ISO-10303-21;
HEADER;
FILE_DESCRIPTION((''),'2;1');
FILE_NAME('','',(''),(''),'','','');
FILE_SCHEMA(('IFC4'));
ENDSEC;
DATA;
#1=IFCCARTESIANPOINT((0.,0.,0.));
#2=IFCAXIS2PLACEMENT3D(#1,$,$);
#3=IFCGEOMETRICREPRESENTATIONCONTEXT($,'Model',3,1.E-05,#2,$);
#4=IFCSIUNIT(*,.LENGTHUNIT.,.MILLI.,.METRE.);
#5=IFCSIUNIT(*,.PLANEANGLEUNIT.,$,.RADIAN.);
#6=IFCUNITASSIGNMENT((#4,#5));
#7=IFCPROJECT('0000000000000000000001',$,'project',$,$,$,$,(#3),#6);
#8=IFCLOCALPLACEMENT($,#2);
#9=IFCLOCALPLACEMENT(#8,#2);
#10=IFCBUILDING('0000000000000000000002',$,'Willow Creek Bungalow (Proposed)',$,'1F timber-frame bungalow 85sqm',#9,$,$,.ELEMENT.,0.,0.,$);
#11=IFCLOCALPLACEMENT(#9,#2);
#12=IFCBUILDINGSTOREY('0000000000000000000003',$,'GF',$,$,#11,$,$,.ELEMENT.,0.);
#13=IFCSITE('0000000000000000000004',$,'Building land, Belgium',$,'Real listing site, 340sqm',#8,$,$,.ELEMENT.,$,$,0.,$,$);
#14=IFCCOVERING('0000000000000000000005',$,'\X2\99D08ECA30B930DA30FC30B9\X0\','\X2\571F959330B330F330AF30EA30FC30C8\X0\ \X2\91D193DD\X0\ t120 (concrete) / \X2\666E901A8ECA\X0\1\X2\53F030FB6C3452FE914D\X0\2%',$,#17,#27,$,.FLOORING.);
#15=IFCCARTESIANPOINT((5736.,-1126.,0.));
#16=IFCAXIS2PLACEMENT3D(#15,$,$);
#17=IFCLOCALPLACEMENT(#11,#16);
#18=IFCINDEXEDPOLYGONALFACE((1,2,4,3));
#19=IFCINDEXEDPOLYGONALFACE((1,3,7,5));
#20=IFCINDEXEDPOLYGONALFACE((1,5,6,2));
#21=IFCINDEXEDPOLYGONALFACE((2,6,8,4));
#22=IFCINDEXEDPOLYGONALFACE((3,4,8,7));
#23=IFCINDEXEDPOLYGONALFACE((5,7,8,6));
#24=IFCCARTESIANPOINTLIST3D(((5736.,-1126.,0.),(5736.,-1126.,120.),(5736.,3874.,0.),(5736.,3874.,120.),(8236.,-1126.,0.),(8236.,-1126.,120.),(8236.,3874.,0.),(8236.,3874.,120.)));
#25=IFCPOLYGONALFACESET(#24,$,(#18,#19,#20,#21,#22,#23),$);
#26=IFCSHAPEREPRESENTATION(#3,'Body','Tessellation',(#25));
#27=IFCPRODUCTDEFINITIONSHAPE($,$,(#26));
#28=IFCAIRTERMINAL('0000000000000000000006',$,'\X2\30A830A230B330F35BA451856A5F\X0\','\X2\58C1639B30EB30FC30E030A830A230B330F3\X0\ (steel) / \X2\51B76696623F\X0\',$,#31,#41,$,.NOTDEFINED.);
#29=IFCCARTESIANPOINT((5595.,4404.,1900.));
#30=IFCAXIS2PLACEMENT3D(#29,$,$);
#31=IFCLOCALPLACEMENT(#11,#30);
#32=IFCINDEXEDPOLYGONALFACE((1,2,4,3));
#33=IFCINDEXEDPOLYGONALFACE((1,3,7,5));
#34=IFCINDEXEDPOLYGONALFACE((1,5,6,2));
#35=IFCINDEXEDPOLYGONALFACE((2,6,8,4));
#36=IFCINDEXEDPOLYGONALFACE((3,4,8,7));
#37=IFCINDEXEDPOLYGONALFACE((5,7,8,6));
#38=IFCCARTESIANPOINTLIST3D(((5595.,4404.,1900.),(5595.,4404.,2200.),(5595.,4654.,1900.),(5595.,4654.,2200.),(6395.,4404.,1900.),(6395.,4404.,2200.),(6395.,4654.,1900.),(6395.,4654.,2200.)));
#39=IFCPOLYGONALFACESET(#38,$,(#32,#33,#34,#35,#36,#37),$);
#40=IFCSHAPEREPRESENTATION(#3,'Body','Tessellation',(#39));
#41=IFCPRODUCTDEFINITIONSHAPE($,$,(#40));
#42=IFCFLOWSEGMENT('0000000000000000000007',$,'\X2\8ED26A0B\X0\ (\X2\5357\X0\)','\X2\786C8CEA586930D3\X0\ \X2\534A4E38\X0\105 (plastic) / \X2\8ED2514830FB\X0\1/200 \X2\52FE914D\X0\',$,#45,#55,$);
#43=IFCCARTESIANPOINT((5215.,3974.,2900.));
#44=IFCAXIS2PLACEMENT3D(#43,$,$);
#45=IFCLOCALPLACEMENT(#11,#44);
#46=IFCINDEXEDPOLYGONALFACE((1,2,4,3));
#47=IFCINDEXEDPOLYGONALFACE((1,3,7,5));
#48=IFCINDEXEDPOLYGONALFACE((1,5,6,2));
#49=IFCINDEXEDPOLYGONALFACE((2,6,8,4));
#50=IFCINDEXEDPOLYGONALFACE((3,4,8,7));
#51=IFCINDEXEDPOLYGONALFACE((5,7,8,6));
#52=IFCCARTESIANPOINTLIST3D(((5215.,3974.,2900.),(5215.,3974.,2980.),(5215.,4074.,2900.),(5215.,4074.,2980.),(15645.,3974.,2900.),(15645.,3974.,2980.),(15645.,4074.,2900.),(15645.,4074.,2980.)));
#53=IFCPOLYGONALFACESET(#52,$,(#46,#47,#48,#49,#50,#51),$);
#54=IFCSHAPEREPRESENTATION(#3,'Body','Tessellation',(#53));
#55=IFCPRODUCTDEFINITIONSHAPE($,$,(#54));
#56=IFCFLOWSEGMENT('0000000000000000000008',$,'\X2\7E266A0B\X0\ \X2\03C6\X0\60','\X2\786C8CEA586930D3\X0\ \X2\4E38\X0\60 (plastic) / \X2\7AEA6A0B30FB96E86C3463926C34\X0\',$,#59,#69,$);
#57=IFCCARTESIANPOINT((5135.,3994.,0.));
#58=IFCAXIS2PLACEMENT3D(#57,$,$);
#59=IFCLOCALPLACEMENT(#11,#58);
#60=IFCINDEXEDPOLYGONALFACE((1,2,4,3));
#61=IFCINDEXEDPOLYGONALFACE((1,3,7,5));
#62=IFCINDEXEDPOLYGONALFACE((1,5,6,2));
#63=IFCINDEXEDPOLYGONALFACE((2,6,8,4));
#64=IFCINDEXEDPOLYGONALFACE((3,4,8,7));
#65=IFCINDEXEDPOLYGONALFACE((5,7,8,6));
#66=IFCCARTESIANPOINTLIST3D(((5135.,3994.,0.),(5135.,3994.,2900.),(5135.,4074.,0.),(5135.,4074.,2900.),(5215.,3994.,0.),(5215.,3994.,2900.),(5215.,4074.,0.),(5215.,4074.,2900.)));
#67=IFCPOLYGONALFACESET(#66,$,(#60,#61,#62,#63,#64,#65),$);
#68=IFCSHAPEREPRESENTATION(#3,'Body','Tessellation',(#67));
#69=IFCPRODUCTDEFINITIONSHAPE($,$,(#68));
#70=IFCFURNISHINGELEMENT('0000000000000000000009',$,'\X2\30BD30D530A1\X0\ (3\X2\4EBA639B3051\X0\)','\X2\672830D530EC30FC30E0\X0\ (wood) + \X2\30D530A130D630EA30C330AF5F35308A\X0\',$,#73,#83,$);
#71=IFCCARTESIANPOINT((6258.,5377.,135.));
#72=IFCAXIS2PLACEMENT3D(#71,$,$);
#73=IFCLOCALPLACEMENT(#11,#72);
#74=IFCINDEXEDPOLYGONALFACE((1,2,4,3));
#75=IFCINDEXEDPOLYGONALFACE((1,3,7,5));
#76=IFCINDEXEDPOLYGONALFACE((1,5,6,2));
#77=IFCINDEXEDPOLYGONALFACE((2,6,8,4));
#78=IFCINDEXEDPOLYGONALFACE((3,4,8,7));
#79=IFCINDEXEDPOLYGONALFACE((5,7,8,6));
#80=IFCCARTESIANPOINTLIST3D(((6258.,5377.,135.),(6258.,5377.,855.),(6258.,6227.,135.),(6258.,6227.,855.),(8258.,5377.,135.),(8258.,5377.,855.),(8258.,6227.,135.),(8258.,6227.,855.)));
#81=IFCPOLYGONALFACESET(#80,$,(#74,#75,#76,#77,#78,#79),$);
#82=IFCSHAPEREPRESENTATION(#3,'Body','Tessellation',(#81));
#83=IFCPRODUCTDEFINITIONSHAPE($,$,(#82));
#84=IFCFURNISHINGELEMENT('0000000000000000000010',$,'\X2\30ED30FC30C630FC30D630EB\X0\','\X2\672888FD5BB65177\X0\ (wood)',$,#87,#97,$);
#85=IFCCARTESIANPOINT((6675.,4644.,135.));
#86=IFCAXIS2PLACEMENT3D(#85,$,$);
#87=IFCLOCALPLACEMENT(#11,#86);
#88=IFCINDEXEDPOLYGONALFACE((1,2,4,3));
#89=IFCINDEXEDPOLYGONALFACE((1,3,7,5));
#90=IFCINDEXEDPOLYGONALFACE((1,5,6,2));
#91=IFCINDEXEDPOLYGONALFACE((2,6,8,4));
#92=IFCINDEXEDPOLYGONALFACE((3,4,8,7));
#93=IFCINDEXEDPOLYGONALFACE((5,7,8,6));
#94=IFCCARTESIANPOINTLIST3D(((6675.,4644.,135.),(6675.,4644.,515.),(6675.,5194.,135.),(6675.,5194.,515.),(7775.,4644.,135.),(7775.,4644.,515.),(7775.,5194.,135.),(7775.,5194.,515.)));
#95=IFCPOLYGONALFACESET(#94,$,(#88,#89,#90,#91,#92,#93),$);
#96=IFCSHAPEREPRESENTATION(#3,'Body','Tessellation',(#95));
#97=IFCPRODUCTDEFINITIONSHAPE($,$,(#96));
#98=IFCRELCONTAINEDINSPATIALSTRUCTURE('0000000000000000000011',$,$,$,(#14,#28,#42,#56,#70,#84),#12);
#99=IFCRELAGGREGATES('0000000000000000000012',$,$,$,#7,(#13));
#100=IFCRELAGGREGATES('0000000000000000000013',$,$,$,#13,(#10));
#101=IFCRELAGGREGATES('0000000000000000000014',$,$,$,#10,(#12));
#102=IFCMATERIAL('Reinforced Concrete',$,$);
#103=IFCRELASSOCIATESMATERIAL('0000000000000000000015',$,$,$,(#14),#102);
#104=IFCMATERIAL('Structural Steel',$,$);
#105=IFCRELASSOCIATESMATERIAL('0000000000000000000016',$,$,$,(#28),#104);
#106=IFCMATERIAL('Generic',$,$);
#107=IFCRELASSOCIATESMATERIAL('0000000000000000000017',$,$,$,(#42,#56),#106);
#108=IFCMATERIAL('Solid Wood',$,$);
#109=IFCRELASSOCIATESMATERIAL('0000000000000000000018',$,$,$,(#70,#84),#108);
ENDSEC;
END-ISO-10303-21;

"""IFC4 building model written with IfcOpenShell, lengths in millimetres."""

from ifc_helpers import new_model, si_unit, frame, frame_2d, origin, place, context, project, spatial, rectangle, extrude, material, element, save


model = new_model("IFC4")

# Units and contexts
model_context = context("Model", 3, precision=1e-05, world=origin())
ifc_project = project(units=[si_unit("LENGTHUNIT", "METRE", prefix="MILLI"), si_unit("PLANEANGLEUNIT", "RADIAN")], contexts=[model_context])

# Site, building, storey
site_placement = place(None, origin())
site = spatial("IfcSite", under=ifc_project, at=site_placement, Name="Building land, Belgium", ObjectType="Real listing site, 340sqm", CompositionType="ELEMENT", RefElevation=0.0)
building_placement = place(site_placement, origin())
building = spatial("IfcBuilding", under=site, at=building_placement, Name="Willow Creek Bungalow (Proposed)", ObjectType="1F timber-frame bungalow 85sqm", CompositionType="ELEMENT", ElevationOfRefHeight=0.0, ElevationOfTerrain=0.0)
storey_placement = place(building_placement, origin())
storey = spatial("IfcBuildingStorey", under=building, at=storey_placement, Name="GF", CompositionType="ELEMENT", Elevation=0.0)

# Shared definitions
ifc_material_1 = material(Name="Solid Wood")

# Shared definitions
ifc_material_2 = material(Name="Reinforced Concrete")

# Shared definitions
ifc_material_3 = material(Name="Structural Steel")

# Covering
ifc_material_4 = material(Name="Generic")
covering_1_placement = place(storey_placement, frame((5736.0, -1126.0, 0.0)))
element("IfcCovering", 1, at=covering_1_placement, inside=storey, material=ifc_material_2, Name="駐車スペース", Description="土間コンクリート 金鏝 t120 (concrete) / 普通車1台・水勾配2%", PredefinedType="FLOORING", context=model_context, shape_type="SweptSolid", body=[
    extrude(rectangle(XDim=2500.0, YDim=5000.0, at=frame_2d((1250.0, 2500.0))), frame((5736.0, -1126.0, 0.0)), (0.0, 0.0, 1.0), 120.0),
])

# Air terminal
air_terminal_placement = place(storey_placement, frame((5595.0, 4404.0, 1900.0)))
element("IfcAirTerminal", 2, at=air_terminal_placement, inside=storey, material=ifc_material_3, Name="エアコン室内機", Description="壁掛ルームエアコン (steel) / 冷暖房", PredefinedType="NOTDEFINED", context=model_context, shape_type="SweptSolid", body=[
    extrude(rectangle(XDim=800.0, YDim=250.0, at=frame_2d((400.0, 125.0))), frame((5595.0, 4404.0, 1900.0)), (0.0, 0.0, 1.0), 300.0),
])

# Flow segments
flow_segment_1_placement = place(storey_placement, frame((5215.0, 3974.0, 2900.0)))
element("IfcFlowSegment", 3, at=flow_segment_1_placement, inside=storey, material=ifc_material_4, Name="軒樋 (南)", Description="硬質塩ビ 半丸105 (plastic) / 軒先・1/200 勾配", context=model_context, shape_type="SweptSolid", body=[
    extrude(rectangle(XDim=10430.0, YDim=100.0, at=frame_2d((5215.0, 50.0))), frame((5215.0, 3974.0, 2900.0)), (0.0, 0.0, 1.0), 80.0),
])
flow_segment_2_placement = place(storey_placement, frame((5135.0, 3994.0, 0.0)))
element("IfcFlowSegment", 4, at=flow_segment_2_placement, inside=storey, material=ifc_material_4, Name="縦樋 φ60", Description="硬質塩ビ 丸60 (plastic) / 竪樋・雨水排水", context=model_context, shape_type="SweptSolid", body=[
    extrude(rectangle(XDim=80.0, YDim=80.0, at=frame_2d((40.0, 40.0))), frame((5135.0, 3994.0, 0.0)), (0.0, 0.0, 1.0), 2900.0),
])

# Furnishing elements
furnishing_1_placement = place(storey_placement, frame((6258.0, 5377.0, 135.0)))
element("IfcFurnishingElement", 5, at=furnishing_1_placement, inside=storey, material=ifc_material_1, Name="ソファ (3人掛け)", Description="木フレーム (wood) + ファブリック張り", context=model_context, shape_type="SweptSolid", body=[
    extrude(rectangle(XDim=2000.0, YDim=850.0, at=frame_2d((1000.0, 425.0))), frame((6258.0, 5377.0, 135.0)), (0.0, 0.0, 1.0), 720.0),
])
furnishing_2_placement = place(storey_placement, frame((6675.0, 4644.0, 135.0)))
element("IfcFurnishingElement", 6, at=furnishing_2_placement, inside=storey, material=ifc_material_1, Name="ローテーブル", Description="木製家具 (wood)", context=model_context, shape_type="SweptSolid", body=[
    extrude(rectangle(XDim=1100.0, YDim=550.0, at=frame_2d((550.0, 275.0))), frame((6675.0, 4644.0, 135.0)), (0.0, 0.0, 1.0), 380.0),
])

save(model, "model.ifc")
